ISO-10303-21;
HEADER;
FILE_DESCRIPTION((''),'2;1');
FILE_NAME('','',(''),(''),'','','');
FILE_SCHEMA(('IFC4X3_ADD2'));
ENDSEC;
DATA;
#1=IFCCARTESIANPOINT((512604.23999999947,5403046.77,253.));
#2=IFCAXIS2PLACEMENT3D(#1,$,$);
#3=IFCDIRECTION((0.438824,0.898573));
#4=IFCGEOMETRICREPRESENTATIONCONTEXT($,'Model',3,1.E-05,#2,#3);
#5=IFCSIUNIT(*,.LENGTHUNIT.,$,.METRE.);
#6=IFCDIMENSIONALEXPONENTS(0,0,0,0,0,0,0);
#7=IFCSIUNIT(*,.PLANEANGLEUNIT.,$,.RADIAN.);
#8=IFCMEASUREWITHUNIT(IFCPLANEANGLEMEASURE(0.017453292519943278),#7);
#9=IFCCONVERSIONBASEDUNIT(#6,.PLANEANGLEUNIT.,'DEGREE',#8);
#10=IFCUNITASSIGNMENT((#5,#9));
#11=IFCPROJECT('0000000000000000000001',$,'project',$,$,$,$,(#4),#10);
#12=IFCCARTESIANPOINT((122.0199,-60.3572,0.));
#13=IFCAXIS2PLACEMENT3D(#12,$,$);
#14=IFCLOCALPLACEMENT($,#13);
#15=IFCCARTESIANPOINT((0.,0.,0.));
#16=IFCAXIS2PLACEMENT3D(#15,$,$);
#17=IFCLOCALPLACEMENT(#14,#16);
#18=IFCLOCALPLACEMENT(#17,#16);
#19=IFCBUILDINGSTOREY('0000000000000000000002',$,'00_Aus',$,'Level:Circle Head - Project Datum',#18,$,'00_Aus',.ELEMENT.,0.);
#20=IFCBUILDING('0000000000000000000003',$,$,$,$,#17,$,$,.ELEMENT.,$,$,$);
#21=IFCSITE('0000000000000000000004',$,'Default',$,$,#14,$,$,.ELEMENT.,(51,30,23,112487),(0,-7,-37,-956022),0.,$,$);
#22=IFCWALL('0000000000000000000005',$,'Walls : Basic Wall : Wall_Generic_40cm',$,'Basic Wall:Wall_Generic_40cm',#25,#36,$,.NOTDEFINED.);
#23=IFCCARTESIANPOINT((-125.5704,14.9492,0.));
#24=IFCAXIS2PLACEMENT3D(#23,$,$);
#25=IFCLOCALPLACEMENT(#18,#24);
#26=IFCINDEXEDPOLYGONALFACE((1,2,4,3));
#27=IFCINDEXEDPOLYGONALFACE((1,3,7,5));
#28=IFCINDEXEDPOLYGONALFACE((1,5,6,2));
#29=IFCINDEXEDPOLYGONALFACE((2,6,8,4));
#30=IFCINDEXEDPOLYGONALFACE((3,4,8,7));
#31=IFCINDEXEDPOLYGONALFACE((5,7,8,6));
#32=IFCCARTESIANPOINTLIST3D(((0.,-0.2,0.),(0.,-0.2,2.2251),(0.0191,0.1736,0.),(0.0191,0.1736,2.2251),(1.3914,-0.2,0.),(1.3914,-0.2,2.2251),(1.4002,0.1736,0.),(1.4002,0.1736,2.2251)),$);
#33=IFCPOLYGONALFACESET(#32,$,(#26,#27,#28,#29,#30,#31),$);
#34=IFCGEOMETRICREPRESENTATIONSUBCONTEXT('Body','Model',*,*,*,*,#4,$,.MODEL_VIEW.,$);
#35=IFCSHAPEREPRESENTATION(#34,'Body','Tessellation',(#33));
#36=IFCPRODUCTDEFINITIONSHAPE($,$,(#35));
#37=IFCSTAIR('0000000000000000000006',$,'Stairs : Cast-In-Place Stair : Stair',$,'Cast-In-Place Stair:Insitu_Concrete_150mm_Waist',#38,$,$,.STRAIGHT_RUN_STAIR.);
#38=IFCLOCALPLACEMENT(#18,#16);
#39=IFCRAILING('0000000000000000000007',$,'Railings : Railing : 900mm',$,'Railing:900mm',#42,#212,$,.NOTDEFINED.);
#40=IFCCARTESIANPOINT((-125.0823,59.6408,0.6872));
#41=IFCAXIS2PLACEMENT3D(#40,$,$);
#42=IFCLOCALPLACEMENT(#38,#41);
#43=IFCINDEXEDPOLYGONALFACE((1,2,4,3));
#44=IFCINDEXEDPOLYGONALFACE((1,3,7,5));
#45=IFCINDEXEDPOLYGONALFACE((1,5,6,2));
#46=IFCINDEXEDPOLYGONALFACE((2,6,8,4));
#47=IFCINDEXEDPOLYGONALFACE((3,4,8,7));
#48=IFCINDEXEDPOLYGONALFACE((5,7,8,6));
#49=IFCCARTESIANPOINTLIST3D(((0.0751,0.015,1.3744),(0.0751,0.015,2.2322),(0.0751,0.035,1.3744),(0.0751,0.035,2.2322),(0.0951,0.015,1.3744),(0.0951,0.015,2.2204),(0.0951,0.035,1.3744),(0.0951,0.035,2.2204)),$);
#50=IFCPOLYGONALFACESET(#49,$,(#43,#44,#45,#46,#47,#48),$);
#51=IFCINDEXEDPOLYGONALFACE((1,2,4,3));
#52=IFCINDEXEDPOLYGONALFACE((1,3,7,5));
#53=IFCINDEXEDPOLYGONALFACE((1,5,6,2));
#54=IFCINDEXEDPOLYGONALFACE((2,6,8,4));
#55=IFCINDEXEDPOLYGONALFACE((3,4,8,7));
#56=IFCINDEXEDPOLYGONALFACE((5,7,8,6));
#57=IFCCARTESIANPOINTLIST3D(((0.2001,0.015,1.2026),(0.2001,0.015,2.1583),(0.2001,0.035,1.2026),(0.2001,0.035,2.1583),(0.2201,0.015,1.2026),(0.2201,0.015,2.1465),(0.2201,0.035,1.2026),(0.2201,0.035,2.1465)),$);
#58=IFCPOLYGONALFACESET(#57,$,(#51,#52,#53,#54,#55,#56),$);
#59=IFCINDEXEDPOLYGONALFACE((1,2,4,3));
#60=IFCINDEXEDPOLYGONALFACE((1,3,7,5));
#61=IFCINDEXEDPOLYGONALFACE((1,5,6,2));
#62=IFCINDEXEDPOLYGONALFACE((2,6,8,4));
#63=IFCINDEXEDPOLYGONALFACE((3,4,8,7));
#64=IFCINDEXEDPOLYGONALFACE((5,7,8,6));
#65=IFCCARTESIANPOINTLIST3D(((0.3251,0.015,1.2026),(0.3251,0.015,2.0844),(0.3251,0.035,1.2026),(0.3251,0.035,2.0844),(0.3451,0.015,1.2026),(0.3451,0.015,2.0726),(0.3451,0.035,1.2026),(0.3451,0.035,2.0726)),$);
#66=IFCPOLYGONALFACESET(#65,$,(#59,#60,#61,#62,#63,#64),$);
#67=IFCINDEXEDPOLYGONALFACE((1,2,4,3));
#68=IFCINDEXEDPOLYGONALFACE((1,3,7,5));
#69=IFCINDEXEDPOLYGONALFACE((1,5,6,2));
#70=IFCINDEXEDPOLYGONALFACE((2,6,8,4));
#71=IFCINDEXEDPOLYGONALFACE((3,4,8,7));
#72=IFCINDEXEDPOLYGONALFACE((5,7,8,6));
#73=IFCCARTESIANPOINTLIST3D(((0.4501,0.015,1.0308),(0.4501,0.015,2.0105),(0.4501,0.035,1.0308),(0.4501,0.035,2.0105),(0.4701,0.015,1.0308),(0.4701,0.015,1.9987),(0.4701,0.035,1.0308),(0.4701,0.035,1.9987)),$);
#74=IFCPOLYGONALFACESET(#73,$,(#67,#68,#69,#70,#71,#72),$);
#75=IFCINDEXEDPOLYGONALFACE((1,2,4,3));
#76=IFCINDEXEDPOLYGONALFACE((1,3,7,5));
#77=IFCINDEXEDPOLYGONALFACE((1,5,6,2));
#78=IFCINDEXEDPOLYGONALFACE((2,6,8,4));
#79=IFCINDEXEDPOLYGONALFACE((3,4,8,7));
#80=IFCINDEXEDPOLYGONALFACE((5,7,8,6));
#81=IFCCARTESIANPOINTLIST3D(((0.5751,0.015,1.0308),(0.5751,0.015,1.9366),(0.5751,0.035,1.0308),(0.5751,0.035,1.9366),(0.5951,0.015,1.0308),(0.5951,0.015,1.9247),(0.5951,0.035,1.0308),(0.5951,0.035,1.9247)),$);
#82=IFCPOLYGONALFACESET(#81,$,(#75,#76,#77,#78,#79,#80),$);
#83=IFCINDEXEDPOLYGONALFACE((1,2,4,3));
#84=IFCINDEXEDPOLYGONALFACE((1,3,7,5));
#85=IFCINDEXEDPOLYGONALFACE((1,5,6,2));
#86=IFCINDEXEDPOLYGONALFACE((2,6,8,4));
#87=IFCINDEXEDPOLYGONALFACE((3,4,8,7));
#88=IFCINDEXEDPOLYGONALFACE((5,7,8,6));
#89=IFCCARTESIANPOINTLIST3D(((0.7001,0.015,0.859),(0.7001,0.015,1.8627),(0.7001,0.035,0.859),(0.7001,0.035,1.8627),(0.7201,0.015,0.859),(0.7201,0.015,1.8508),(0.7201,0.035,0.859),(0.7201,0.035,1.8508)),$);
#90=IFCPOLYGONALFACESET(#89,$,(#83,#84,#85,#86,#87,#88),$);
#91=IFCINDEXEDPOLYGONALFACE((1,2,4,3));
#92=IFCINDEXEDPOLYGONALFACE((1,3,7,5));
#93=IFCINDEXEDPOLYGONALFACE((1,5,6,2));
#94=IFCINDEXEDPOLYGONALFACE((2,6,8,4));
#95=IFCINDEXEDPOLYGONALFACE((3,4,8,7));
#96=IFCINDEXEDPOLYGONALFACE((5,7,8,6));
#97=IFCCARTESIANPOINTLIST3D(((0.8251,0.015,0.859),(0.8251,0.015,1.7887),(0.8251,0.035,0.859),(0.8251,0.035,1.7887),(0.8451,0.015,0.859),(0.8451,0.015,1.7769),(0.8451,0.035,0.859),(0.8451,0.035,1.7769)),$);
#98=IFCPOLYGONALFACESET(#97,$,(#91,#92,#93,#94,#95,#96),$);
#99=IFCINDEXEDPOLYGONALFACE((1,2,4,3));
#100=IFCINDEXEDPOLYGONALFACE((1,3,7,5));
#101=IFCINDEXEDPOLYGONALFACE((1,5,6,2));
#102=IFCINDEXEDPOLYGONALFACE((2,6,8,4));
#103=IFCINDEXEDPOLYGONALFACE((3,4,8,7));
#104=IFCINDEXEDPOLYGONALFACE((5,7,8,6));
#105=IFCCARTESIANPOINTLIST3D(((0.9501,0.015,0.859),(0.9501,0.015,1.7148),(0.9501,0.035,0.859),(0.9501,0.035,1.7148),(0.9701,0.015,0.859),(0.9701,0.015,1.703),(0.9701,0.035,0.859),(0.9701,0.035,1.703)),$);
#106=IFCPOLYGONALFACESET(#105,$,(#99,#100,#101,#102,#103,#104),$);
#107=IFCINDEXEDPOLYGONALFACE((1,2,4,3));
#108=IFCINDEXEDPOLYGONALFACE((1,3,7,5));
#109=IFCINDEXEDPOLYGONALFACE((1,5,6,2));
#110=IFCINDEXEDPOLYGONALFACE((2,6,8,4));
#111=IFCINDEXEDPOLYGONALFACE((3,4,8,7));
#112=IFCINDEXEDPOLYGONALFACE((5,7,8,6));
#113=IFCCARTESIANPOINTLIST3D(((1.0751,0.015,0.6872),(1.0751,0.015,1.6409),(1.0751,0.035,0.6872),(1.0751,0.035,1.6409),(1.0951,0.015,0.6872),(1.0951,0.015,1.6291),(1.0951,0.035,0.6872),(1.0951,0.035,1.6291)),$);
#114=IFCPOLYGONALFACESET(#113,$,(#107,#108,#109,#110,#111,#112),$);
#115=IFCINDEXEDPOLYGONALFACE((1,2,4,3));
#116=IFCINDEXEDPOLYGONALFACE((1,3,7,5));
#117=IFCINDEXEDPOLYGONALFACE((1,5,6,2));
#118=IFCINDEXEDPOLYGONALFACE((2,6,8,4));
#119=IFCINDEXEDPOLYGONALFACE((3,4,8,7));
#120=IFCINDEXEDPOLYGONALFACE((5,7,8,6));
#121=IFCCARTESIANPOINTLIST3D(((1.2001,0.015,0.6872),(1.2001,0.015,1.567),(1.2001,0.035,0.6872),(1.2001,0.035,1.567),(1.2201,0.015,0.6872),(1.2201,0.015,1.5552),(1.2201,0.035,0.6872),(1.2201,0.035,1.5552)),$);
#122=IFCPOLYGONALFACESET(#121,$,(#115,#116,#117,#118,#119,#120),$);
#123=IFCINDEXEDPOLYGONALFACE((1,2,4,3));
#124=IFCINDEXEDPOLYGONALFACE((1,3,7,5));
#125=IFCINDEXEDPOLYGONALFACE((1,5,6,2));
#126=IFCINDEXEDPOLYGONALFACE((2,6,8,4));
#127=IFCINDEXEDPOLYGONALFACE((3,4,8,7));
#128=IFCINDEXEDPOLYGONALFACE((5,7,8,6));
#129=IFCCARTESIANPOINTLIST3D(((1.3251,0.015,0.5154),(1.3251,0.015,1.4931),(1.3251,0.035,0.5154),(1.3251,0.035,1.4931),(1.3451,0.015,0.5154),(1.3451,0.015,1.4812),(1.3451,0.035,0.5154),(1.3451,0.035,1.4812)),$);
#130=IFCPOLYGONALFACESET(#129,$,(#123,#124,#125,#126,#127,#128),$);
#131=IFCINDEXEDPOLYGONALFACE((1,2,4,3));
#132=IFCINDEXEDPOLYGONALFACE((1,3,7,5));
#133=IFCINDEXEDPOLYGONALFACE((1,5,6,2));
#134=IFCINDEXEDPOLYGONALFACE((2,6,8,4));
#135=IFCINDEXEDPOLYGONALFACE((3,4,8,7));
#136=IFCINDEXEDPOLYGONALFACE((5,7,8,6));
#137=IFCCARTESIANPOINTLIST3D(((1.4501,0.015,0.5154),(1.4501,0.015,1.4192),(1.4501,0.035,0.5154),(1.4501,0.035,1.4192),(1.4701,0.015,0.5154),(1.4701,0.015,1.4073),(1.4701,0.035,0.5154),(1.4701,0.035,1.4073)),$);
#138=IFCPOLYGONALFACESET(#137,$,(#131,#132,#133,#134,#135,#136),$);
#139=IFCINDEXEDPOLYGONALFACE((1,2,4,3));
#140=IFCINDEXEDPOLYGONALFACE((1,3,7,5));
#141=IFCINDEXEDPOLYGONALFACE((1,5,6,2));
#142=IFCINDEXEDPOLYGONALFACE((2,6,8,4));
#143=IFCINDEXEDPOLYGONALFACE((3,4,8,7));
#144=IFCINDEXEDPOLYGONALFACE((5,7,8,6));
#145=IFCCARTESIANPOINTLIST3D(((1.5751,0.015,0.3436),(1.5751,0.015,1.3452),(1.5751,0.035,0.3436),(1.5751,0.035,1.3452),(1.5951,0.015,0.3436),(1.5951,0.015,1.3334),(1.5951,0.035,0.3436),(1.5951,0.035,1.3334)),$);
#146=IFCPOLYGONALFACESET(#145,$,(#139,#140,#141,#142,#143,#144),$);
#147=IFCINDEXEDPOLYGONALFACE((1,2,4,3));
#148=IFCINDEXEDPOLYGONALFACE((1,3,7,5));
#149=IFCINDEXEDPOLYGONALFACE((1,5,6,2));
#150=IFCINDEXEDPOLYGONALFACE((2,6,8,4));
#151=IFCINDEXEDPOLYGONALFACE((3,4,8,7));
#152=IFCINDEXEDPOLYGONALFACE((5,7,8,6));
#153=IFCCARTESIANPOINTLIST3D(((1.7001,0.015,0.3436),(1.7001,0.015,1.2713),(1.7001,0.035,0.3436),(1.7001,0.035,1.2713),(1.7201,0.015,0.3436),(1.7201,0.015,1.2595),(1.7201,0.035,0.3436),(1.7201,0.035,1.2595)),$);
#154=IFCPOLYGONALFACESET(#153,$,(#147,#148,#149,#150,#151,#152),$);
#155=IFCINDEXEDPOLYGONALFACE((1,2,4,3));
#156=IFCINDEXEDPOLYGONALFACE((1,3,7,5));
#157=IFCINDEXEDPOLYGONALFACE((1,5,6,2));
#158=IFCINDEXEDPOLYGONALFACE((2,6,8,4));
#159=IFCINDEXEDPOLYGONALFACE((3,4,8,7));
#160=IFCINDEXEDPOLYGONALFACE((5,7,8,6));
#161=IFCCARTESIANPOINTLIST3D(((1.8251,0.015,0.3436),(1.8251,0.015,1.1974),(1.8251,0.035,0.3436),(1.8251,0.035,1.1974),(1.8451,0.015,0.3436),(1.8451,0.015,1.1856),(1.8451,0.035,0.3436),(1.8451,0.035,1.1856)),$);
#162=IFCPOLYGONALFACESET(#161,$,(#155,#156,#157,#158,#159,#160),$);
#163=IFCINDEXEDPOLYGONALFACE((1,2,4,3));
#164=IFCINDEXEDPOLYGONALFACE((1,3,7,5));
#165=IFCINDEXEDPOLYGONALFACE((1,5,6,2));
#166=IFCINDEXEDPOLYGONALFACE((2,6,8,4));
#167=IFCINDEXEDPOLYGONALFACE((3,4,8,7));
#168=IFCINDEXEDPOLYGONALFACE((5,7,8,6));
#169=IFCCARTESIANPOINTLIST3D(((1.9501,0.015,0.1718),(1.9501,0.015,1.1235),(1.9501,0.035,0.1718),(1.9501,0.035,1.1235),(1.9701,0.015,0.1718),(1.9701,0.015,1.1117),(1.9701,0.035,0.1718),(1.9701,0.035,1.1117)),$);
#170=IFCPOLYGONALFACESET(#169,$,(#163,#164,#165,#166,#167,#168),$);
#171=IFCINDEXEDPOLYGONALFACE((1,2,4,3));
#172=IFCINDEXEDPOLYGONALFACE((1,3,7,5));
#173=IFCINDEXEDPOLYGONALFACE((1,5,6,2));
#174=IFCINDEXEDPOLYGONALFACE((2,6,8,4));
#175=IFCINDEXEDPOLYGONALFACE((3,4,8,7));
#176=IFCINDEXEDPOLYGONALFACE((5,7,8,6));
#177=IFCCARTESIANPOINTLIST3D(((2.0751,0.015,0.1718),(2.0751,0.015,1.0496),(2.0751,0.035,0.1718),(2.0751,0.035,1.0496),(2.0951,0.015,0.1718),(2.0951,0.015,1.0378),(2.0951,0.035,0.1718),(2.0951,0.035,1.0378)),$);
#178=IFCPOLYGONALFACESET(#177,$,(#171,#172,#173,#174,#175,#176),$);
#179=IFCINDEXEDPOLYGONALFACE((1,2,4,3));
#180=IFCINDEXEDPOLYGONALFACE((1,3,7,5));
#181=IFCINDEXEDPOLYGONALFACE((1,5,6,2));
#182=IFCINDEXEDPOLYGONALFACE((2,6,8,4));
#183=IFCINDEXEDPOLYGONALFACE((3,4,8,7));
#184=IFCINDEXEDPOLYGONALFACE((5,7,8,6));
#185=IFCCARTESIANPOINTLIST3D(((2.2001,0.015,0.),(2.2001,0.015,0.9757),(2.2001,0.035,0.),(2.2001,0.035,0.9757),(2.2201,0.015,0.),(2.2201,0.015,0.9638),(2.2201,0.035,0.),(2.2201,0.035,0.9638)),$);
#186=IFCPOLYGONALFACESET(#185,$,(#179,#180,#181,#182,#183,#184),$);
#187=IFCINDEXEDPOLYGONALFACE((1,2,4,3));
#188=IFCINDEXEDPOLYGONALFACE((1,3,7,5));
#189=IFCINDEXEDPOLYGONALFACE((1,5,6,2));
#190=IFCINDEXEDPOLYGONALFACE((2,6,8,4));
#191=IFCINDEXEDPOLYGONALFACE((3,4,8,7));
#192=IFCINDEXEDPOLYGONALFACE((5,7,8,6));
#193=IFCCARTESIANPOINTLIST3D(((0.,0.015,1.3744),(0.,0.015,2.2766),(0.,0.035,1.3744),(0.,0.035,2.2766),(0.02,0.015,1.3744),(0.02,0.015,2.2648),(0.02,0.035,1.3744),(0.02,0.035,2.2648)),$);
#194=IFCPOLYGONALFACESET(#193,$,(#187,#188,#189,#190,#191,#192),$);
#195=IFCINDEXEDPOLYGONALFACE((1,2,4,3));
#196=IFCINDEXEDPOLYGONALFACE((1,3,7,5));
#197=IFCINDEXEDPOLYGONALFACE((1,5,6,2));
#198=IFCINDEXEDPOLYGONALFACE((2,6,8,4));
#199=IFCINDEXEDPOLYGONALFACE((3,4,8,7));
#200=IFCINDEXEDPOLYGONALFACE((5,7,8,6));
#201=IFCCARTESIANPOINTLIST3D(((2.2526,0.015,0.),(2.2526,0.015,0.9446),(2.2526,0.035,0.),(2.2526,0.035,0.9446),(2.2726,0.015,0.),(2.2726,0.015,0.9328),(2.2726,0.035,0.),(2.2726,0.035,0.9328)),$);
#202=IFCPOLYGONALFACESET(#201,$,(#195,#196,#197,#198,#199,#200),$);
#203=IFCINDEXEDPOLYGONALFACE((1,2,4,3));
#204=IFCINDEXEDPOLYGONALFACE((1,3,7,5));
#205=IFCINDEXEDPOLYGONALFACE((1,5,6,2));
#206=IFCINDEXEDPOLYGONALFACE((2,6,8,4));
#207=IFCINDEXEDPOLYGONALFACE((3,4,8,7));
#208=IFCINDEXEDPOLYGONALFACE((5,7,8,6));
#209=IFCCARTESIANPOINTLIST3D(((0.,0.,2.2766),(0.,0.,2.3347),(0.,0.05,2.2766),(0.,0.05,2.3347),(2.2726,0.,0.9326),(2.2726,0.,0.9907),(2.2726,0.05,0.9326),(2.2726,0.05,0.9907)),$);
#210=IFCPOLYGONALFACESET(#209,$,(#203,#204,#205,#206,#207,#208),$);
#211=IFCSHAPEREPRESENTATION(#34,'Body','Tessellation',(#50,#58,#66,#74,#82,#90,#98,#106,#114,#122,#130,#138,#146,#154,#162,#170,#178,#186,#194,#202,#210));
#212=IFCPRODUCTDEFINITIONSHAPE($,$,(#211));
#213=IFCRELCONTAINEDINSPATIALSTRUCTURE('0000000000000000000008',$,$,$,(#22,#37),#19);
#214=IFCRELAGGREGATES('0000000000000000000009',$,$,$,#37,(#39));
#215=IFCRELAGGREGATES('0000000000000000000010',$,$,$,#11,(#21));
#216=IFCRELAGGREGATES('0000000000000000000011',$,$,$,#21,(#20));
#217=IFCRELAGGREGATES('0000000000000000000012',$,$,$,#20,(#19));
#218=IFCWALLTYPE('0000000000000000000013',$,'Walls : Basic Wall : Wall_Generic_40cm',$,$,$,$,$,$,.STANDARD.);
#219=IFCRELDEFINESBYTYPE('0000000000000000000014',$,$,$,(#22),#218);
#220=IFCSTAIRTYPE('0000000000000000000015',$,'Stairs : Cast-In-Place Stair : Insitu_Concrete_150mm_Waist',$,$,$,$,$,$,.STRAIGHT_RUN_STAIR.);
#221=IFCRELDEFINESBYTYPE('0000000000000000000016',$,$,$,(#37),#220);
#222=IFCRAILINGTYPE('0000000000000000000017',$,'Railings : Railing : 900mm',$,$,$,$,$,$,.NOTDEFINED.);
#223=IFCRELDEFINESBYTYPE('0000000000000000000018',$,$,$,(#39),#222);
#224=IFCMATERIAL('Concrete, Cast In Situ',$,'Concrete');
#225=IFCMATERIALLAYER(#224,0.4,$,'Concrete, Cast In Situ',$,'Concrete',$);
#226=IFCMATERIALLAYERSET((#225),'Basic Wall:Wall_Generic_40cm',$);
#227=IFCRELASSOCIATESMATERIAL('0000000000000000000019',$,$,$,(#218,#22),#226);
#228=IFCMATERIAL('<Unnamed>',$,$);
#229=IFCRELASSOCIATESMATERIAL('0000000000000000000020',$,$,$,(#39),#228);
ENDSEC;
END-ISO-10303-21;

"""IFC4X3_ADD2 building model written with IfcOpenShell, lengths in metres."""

from ifc_helpers import new_model, entity, si_unit, converted_unit, direction, frame, origin, place, context, subcontext, project, spatial, polyline, outline, extrude, clip, halfspace, bounded_halfspace, material, layer, layer_set, type_object, element, aggregate, save


model = new_model("IFC4X3_ADD2")

# Units and contexts
model_context = context("Model", 3, precision=1e-05, world=frame((512604.23999999947, 5403046.77, 253.0)), true_north=direction((0.438824, 0.898573)))
body_context = subcontext(model_context, "Body", "Model", "MODEL_VIEW")
ifc_project = project(units=[si_unit("LENGTHUNIT", "METRE"), converted_unit("PLANEANGLEUNIT", "DEGREE", entity("IfcPlaneAngleMeasure", 0.017453292519943278), si_unit("PLANEANGLEUNIT", "RADIAN"), dimensions=[0, 0, 0, 0, 0, 0, 0])], contexts=[model_context])

# Site, building, storey
site_placement = place(None, frame((122.0199, -60.3572, 0.0)))
site = spatial("IfcSite", under=ifc_project, at=site_placement, Name="Default", CompositionType="ELEMENT", RefLatitude=(51, 30, 23, 112487), RefLongitude=(0, -7, -37, -956022), RefElevation=0.0)
building_placement = place(site_placement, origin())
building = spatial("IfcBuilding", under=site, at=building_placement, CompositionType="ELEMENT")
storey_placement = place(building_placement, origin())
storey = spatial("IfcBuildingStorey", under=building, at=storey_placement, Name="00_Aus", ObjectType="Level:Circle Head - Project Datum", LongName="00_Aus", CompositionType="ELEMENT", Elevation=0.0)

# Wall
ifc_material_1 = material(Name="Concrete, Cast In Situ", Category="Concrete")
ifc_layer_1 = layer(ifc_material_1, 0.4, Name="Concrete, Cast In Situ", Category="Concrete")
ifc_layer_set_1 = layer_set([ifc_layer_1], Name="Basic Wall:Wall_Generic_40cm")
wall_type_1 = type_object("IfcWallType", Name="Walls : Basic Wall : Wall_Generic_40cm", PredefinedType="STANDARD", material=ifc_layer_set_1)
wall_1_placement = place(storey_placement, frame((-125.5704, 14.9492, 0.0)))
element("IfcWall", 1, at=wall_1_placement, inside=storey, type_object=wall_type_1, material=ifc_layer_set_1, Name="Walls : Basic Wall : Wall_Generic_40cm", ObjectType="Basic Wall:Wall_Generic_40cm", PredefinedType="NOTDEFINED", context=body_context, shape_type="Clipping", body=[
    clip(clip(extrude(outline(polyline([(1.3914, -0.2), (1.4002, 0.1736), (0.0191, 0.1736), (0.0, -0.2), (1.3914, -0.2)])), origin(), (0.0, 0.0, 1.0), 2.2251), bounded_halfspace(frame((1.4002, 0.1736, -0.66), z_axis=(0.0, -1.0, 0.0), x_axis=(1.0, 0.0, 0.0)), True, frame((1.4002, 0.1736, -0.66), z_axis=(0.0, -1.0, 0.0), x_axis=(1.0, 0.0, 0.0)), polyline([(0.0, 0.0), (0.0, 2.8851), (-1.3812, 2.8851), (-1.3812, 0.0), (0.0, 0.0)]))), halfspace(frame((0.0, 0.0, -0.66)), True)),
])

# Stair, railing
stair_type = type_object("IfcStairType", Name="Stairs : Cast-In-Place Stair : Insitu_Concrete_150mm_Waist", PredefinedType="STRAIGHT_RUN_STAIR")
stair_placement = place(storey_placement, origin())
stair = element("IfcStair", 2, at=stair_placement, inside=storey, type_object=stair_type, Name="Stairs : Cast-In-Place Stair : Stair", ObjectType="Cast-In-Place Stair:Insitu_Concrete_150mm_Waist", PredefinedType="STRAIGHT_RUN_STAIR")
ifc_material_2 = material(Name="<Unnamed>")
railing_type = type_object("IfcRailingType", Name="Railings : Railing : 900mm", PredefinedType="NOTDEFINED")
railing_placement = place(stair_placement, frame((-125.0823, 59.6408, 0.6872)))
railing = element("IfcRailing", 3, at=railing_placement, type_object=railing_type, material=ifc_material_2, Name="Railings : Railing : 900mm", ObjectType="Railing:900mm", PredefinedType="NOTDEFINED", context=body_context, shape_type="SweptSolid", body=[
    extrude(outline(polyline([(-0.01, -0.426), (0.01, -0.426), (0.01, 0.4319), (-0.01, 0.4201), (-0.01, -0.426)])), frame((0.0851, 0.015, 1.8003), z_axis=(0.0, 1.0, 0.0), x_axis=(-1.0, 0.0, 0.0)), (0.0, 0.0, 1.0), 0.02),
    extrude(outline(polyline([(-0.01, -0.4749), (0.01, -0.4749), (0.01, 0.4808), (-0.01, 0.469), (-0.01, -0.4749)])), frame((0.2101, 0.015, 1.6775), z_axis=(0.0, 1.0, 0.0), x_axis=(-1.0, 0.0, 0.0)), (0.0, 0.0, 1.0), 0.02),
    extrude(outline(polyline([(-0.01, -0.438), (0.01, -0.438), (0.01, 0.4439), (-0.01, 0.432), (-0.01, -0.438)])), frame((0.3351, 0.015, 1.6405), z_axis=(0.0, 1.0, 0.0), x_axis=(-1.0, 0.0, 0.0)), (0.0, 0.0, 1.0), 0.02),
    extrude(outline(polyline([(-0.01, -0.4869), (0.01, -0.4869), (0.01, 0.4928), (-0.01, 0.481), (-0.01, -0.4869)])), frame((0.4601, 0.015, 1.5177), z_axis=(0.0, 1.0, 0.0), x_axis=(-1.0, 0.0, 0.0)), (0.0, 0.0, 1.0), 0.02),
    extrude(outline(polyline([(-0.01, -0.4499), (0.01, -0.4499), (0.01, 0.4559), (-0.01, 0.444), (-0.01, -0.4499)])), frame((0.5851, 0.015, 1.4807), z_axis=(0.0, 1.0, 0.0), x_axis=(-1.0, 0.0, 0.0)), (0.0, 0.0, 1.0), 0.02),
    extrude(outline(polyline([(-0.01, -0.4989), (0.01, -0.4989), (0.01, 0.5048), (-0.01, 0.493), (-0.01, -0.4989)])), frame((0.7101, 0.015, 1.3579), z_axis=(0.0, 1.0, 0.0), x_axis=(-1.0, 0.0, 0.0)), (0.0, 0.0, 1.0), 0.02),
    extrude(outline(polyline([(-0.01, -0.4619), (0.01, -0.4619), (0.01, 0.4678), (-0.01, 0.456), (-0.01, -0.4619)])), frame((0.8351, 0.015, 1.3209), z_axis=(0.0, 1.0, 0.0), x_axis=(-1.0, 0.0, 0.0)), (0.0, 0.0, 1.0), 0.02),
    extrude(outline(polyline([(-0.01, -0.425), (0.01, -0.425), (0.01, 0.4309), (-0.01, 0.4191), (-0.01, -0.425)])), frame((0.9601, 0.015, 1.2839), z_axis=(0.0, 1.0, 0.0), x_axis=(-1.0, 0.0, 0.0)), (0.0, 0.0, 1.0), 0.02),
    extrude(outline(polyline([(-0.01, -0.4739), (0.01, -0.4739), (0.01, 0.4798), (-0.01, 0.468), (-0.01, -0.4739)])), frame((1.0851, 0.015, 1.1611), z_axis=(0.0, 1.0, 0.0), x_axis=(-1.0, 0.0, 0.0)), (0.0, 0.0, 1.0), 0.02),
    extrude(outline(polyline([(-0.01, -0.4369), (0.01, -0.4369), (0.01, 0.4429), (-0.01, 0.431), (-0.01, -0.4369)])), frame((1.2101, 0.015, 1.1241), z_axis=(0.0, 1.0, 0.0), x_axis=(-1.0, 0.0, 0.0)), (0.0, 0.0, 1.0), 0.02),
    extrude(outline(polyline([(-0.01, -0.4859), (0.01, -0.4859), (0.01, 0.4918), (-0.01, 0.48), (-0.01, -0.4859)])), frame((1.3351, 0.015, 1.0013), z_axis=(0.0, 1.0, 0.0), x_axis=(-1.0, 0.0, 0.0)), (0.0, 0.0, 1.0), 0.02),
    extrude(outline(polyline([(-0.01, -0.4489), (0.01, -0.4489), (0.01, 0.4548), (-0.01, 0.443), (-0.01, -0.4489)])), frame((1.4601, 0.015, 0.9643), z_axis=(0.0, 1.0, 0.0), x_axis=(-1.0, 0.0, 0.0)), (0.0, 0.0, 1.0), 0.02),
    extrude(outline(polyline([(-0.01, -0.4979), (0.01, -0.4979), (0.01, 0.5038), (-0.01, 0.492), (-0.01, -0.4979)])), frame((1.5851, 0.015, 0.8415), z_axis=(0.0, 1.0, 0.0), x_axis=(-1.0, 0.0, 0.0)), (0.0, 0.0, 1.0), 0.02),
    extrude(outline(polyline([(-0.01, -0.4609), (0.01, -0.4609), (0.01, 0.4668), (-0.01, 0.455), (-0.01, -0.4609)])), frame((1.7101, 0.015, 0.8045), z_axis=(0.0, 1.0, 0.0), x_axis=(-1.0, 0.0, 0.0)), (0.0, 0.0, 1.0), 0.02),
    extrude(outline(polyline([(-0.01, -0.424), (0.01, -0.424), (0.01, 0.4299), (-0.01, 0.418), (-0.01, -0.424)])), frame((1.8351, 0.015, 0.7675), z_axis=(0.0, 1.0, 0.0), x_axis=(-1.0, 0.0, 0.0)), (0.0, 0.0, 1.0), 0.02),
    extrude(outline(polyline([(-0.01, -0.4729), (0.01, -0.4729), (0.01, 0.4788), (-0.01, 0.467), (-0.01, -0.4729)])), frame((1.9601, 0.015, 0.6447), z_axis=(0.0, 1.0, 0.0), x_axis=(-1.0, 0.0, 0.0)), (0.0, 0.0, 1.0), 0.02),
    extrude(outline(polyline([(-0.01, -0.4359), (0.01, -0.4359), (0.01, 0.4418), (-0.01, 0.43), (-0.01, -0.4359)])), frame((2.0851, 0.015, 0.6077), z_axis=(0.0, 1.0, 0.0), x_axis=(-1.0, 0.0, 0.0)), (0.0, 0.0, 1.0), 0.02),
    extrude(outline(polyline([(-0.01, -0.4849), (0.01, -0.4849), (0.01, 0.4908), (-0.01, 0.479), (-0.01, -0.4849)])), frame((2.2101, 0.015, 0.4849), z_axis=(0.0, 1.0, 0.0), x_axis=(-1.0, 0.0, 0.0)), (0.0, 0.0, 1.0), 0.02),
    extrude(outline(polyline([(-0.01, -0.4482), (0.01, -0.4482), (0.01, 0.4541), (-0.01, 0.4423), (-0.01, -0.4482)])), frame((0.01, 0.015, 1.8225), z_axis=(0.0, 1.0, 0.0), x_axis=(-1.0, 0.0, 0.0)), (0.0, 0.0, 1.0), 0.02),
    extrude(outline(polyline([(-0.01, -0.4694), (0.01, -0.4694), (0.01, 0.4753), (-0.01, 0.4634), (-0.01, -0.4694)])), frame((2.2626, 0.015, 0.4694), z_axis=(0.0, 1.0, 0.0), x_axis=(-1.0, 0.0, 0.0)), (0.0, 0.0, 1.0), 0.02),
    extrude(outline(polyline([(-1.3349, -0.025), (1.3053, -0.025), (1.3349, 0.025), (-1.3053, 0.025), (-1.3349, -0.025)])), frame((1.1363, 0.0, 1.6337), z_axis=(0.0, 1.0, 0.0), x_axis=(-0.860758, 0.0, 0.509014)), (0.0, 0.0, 1.0), 0.05),
])
aggregate(stair, [railing])

save(model, "model.ifc")
